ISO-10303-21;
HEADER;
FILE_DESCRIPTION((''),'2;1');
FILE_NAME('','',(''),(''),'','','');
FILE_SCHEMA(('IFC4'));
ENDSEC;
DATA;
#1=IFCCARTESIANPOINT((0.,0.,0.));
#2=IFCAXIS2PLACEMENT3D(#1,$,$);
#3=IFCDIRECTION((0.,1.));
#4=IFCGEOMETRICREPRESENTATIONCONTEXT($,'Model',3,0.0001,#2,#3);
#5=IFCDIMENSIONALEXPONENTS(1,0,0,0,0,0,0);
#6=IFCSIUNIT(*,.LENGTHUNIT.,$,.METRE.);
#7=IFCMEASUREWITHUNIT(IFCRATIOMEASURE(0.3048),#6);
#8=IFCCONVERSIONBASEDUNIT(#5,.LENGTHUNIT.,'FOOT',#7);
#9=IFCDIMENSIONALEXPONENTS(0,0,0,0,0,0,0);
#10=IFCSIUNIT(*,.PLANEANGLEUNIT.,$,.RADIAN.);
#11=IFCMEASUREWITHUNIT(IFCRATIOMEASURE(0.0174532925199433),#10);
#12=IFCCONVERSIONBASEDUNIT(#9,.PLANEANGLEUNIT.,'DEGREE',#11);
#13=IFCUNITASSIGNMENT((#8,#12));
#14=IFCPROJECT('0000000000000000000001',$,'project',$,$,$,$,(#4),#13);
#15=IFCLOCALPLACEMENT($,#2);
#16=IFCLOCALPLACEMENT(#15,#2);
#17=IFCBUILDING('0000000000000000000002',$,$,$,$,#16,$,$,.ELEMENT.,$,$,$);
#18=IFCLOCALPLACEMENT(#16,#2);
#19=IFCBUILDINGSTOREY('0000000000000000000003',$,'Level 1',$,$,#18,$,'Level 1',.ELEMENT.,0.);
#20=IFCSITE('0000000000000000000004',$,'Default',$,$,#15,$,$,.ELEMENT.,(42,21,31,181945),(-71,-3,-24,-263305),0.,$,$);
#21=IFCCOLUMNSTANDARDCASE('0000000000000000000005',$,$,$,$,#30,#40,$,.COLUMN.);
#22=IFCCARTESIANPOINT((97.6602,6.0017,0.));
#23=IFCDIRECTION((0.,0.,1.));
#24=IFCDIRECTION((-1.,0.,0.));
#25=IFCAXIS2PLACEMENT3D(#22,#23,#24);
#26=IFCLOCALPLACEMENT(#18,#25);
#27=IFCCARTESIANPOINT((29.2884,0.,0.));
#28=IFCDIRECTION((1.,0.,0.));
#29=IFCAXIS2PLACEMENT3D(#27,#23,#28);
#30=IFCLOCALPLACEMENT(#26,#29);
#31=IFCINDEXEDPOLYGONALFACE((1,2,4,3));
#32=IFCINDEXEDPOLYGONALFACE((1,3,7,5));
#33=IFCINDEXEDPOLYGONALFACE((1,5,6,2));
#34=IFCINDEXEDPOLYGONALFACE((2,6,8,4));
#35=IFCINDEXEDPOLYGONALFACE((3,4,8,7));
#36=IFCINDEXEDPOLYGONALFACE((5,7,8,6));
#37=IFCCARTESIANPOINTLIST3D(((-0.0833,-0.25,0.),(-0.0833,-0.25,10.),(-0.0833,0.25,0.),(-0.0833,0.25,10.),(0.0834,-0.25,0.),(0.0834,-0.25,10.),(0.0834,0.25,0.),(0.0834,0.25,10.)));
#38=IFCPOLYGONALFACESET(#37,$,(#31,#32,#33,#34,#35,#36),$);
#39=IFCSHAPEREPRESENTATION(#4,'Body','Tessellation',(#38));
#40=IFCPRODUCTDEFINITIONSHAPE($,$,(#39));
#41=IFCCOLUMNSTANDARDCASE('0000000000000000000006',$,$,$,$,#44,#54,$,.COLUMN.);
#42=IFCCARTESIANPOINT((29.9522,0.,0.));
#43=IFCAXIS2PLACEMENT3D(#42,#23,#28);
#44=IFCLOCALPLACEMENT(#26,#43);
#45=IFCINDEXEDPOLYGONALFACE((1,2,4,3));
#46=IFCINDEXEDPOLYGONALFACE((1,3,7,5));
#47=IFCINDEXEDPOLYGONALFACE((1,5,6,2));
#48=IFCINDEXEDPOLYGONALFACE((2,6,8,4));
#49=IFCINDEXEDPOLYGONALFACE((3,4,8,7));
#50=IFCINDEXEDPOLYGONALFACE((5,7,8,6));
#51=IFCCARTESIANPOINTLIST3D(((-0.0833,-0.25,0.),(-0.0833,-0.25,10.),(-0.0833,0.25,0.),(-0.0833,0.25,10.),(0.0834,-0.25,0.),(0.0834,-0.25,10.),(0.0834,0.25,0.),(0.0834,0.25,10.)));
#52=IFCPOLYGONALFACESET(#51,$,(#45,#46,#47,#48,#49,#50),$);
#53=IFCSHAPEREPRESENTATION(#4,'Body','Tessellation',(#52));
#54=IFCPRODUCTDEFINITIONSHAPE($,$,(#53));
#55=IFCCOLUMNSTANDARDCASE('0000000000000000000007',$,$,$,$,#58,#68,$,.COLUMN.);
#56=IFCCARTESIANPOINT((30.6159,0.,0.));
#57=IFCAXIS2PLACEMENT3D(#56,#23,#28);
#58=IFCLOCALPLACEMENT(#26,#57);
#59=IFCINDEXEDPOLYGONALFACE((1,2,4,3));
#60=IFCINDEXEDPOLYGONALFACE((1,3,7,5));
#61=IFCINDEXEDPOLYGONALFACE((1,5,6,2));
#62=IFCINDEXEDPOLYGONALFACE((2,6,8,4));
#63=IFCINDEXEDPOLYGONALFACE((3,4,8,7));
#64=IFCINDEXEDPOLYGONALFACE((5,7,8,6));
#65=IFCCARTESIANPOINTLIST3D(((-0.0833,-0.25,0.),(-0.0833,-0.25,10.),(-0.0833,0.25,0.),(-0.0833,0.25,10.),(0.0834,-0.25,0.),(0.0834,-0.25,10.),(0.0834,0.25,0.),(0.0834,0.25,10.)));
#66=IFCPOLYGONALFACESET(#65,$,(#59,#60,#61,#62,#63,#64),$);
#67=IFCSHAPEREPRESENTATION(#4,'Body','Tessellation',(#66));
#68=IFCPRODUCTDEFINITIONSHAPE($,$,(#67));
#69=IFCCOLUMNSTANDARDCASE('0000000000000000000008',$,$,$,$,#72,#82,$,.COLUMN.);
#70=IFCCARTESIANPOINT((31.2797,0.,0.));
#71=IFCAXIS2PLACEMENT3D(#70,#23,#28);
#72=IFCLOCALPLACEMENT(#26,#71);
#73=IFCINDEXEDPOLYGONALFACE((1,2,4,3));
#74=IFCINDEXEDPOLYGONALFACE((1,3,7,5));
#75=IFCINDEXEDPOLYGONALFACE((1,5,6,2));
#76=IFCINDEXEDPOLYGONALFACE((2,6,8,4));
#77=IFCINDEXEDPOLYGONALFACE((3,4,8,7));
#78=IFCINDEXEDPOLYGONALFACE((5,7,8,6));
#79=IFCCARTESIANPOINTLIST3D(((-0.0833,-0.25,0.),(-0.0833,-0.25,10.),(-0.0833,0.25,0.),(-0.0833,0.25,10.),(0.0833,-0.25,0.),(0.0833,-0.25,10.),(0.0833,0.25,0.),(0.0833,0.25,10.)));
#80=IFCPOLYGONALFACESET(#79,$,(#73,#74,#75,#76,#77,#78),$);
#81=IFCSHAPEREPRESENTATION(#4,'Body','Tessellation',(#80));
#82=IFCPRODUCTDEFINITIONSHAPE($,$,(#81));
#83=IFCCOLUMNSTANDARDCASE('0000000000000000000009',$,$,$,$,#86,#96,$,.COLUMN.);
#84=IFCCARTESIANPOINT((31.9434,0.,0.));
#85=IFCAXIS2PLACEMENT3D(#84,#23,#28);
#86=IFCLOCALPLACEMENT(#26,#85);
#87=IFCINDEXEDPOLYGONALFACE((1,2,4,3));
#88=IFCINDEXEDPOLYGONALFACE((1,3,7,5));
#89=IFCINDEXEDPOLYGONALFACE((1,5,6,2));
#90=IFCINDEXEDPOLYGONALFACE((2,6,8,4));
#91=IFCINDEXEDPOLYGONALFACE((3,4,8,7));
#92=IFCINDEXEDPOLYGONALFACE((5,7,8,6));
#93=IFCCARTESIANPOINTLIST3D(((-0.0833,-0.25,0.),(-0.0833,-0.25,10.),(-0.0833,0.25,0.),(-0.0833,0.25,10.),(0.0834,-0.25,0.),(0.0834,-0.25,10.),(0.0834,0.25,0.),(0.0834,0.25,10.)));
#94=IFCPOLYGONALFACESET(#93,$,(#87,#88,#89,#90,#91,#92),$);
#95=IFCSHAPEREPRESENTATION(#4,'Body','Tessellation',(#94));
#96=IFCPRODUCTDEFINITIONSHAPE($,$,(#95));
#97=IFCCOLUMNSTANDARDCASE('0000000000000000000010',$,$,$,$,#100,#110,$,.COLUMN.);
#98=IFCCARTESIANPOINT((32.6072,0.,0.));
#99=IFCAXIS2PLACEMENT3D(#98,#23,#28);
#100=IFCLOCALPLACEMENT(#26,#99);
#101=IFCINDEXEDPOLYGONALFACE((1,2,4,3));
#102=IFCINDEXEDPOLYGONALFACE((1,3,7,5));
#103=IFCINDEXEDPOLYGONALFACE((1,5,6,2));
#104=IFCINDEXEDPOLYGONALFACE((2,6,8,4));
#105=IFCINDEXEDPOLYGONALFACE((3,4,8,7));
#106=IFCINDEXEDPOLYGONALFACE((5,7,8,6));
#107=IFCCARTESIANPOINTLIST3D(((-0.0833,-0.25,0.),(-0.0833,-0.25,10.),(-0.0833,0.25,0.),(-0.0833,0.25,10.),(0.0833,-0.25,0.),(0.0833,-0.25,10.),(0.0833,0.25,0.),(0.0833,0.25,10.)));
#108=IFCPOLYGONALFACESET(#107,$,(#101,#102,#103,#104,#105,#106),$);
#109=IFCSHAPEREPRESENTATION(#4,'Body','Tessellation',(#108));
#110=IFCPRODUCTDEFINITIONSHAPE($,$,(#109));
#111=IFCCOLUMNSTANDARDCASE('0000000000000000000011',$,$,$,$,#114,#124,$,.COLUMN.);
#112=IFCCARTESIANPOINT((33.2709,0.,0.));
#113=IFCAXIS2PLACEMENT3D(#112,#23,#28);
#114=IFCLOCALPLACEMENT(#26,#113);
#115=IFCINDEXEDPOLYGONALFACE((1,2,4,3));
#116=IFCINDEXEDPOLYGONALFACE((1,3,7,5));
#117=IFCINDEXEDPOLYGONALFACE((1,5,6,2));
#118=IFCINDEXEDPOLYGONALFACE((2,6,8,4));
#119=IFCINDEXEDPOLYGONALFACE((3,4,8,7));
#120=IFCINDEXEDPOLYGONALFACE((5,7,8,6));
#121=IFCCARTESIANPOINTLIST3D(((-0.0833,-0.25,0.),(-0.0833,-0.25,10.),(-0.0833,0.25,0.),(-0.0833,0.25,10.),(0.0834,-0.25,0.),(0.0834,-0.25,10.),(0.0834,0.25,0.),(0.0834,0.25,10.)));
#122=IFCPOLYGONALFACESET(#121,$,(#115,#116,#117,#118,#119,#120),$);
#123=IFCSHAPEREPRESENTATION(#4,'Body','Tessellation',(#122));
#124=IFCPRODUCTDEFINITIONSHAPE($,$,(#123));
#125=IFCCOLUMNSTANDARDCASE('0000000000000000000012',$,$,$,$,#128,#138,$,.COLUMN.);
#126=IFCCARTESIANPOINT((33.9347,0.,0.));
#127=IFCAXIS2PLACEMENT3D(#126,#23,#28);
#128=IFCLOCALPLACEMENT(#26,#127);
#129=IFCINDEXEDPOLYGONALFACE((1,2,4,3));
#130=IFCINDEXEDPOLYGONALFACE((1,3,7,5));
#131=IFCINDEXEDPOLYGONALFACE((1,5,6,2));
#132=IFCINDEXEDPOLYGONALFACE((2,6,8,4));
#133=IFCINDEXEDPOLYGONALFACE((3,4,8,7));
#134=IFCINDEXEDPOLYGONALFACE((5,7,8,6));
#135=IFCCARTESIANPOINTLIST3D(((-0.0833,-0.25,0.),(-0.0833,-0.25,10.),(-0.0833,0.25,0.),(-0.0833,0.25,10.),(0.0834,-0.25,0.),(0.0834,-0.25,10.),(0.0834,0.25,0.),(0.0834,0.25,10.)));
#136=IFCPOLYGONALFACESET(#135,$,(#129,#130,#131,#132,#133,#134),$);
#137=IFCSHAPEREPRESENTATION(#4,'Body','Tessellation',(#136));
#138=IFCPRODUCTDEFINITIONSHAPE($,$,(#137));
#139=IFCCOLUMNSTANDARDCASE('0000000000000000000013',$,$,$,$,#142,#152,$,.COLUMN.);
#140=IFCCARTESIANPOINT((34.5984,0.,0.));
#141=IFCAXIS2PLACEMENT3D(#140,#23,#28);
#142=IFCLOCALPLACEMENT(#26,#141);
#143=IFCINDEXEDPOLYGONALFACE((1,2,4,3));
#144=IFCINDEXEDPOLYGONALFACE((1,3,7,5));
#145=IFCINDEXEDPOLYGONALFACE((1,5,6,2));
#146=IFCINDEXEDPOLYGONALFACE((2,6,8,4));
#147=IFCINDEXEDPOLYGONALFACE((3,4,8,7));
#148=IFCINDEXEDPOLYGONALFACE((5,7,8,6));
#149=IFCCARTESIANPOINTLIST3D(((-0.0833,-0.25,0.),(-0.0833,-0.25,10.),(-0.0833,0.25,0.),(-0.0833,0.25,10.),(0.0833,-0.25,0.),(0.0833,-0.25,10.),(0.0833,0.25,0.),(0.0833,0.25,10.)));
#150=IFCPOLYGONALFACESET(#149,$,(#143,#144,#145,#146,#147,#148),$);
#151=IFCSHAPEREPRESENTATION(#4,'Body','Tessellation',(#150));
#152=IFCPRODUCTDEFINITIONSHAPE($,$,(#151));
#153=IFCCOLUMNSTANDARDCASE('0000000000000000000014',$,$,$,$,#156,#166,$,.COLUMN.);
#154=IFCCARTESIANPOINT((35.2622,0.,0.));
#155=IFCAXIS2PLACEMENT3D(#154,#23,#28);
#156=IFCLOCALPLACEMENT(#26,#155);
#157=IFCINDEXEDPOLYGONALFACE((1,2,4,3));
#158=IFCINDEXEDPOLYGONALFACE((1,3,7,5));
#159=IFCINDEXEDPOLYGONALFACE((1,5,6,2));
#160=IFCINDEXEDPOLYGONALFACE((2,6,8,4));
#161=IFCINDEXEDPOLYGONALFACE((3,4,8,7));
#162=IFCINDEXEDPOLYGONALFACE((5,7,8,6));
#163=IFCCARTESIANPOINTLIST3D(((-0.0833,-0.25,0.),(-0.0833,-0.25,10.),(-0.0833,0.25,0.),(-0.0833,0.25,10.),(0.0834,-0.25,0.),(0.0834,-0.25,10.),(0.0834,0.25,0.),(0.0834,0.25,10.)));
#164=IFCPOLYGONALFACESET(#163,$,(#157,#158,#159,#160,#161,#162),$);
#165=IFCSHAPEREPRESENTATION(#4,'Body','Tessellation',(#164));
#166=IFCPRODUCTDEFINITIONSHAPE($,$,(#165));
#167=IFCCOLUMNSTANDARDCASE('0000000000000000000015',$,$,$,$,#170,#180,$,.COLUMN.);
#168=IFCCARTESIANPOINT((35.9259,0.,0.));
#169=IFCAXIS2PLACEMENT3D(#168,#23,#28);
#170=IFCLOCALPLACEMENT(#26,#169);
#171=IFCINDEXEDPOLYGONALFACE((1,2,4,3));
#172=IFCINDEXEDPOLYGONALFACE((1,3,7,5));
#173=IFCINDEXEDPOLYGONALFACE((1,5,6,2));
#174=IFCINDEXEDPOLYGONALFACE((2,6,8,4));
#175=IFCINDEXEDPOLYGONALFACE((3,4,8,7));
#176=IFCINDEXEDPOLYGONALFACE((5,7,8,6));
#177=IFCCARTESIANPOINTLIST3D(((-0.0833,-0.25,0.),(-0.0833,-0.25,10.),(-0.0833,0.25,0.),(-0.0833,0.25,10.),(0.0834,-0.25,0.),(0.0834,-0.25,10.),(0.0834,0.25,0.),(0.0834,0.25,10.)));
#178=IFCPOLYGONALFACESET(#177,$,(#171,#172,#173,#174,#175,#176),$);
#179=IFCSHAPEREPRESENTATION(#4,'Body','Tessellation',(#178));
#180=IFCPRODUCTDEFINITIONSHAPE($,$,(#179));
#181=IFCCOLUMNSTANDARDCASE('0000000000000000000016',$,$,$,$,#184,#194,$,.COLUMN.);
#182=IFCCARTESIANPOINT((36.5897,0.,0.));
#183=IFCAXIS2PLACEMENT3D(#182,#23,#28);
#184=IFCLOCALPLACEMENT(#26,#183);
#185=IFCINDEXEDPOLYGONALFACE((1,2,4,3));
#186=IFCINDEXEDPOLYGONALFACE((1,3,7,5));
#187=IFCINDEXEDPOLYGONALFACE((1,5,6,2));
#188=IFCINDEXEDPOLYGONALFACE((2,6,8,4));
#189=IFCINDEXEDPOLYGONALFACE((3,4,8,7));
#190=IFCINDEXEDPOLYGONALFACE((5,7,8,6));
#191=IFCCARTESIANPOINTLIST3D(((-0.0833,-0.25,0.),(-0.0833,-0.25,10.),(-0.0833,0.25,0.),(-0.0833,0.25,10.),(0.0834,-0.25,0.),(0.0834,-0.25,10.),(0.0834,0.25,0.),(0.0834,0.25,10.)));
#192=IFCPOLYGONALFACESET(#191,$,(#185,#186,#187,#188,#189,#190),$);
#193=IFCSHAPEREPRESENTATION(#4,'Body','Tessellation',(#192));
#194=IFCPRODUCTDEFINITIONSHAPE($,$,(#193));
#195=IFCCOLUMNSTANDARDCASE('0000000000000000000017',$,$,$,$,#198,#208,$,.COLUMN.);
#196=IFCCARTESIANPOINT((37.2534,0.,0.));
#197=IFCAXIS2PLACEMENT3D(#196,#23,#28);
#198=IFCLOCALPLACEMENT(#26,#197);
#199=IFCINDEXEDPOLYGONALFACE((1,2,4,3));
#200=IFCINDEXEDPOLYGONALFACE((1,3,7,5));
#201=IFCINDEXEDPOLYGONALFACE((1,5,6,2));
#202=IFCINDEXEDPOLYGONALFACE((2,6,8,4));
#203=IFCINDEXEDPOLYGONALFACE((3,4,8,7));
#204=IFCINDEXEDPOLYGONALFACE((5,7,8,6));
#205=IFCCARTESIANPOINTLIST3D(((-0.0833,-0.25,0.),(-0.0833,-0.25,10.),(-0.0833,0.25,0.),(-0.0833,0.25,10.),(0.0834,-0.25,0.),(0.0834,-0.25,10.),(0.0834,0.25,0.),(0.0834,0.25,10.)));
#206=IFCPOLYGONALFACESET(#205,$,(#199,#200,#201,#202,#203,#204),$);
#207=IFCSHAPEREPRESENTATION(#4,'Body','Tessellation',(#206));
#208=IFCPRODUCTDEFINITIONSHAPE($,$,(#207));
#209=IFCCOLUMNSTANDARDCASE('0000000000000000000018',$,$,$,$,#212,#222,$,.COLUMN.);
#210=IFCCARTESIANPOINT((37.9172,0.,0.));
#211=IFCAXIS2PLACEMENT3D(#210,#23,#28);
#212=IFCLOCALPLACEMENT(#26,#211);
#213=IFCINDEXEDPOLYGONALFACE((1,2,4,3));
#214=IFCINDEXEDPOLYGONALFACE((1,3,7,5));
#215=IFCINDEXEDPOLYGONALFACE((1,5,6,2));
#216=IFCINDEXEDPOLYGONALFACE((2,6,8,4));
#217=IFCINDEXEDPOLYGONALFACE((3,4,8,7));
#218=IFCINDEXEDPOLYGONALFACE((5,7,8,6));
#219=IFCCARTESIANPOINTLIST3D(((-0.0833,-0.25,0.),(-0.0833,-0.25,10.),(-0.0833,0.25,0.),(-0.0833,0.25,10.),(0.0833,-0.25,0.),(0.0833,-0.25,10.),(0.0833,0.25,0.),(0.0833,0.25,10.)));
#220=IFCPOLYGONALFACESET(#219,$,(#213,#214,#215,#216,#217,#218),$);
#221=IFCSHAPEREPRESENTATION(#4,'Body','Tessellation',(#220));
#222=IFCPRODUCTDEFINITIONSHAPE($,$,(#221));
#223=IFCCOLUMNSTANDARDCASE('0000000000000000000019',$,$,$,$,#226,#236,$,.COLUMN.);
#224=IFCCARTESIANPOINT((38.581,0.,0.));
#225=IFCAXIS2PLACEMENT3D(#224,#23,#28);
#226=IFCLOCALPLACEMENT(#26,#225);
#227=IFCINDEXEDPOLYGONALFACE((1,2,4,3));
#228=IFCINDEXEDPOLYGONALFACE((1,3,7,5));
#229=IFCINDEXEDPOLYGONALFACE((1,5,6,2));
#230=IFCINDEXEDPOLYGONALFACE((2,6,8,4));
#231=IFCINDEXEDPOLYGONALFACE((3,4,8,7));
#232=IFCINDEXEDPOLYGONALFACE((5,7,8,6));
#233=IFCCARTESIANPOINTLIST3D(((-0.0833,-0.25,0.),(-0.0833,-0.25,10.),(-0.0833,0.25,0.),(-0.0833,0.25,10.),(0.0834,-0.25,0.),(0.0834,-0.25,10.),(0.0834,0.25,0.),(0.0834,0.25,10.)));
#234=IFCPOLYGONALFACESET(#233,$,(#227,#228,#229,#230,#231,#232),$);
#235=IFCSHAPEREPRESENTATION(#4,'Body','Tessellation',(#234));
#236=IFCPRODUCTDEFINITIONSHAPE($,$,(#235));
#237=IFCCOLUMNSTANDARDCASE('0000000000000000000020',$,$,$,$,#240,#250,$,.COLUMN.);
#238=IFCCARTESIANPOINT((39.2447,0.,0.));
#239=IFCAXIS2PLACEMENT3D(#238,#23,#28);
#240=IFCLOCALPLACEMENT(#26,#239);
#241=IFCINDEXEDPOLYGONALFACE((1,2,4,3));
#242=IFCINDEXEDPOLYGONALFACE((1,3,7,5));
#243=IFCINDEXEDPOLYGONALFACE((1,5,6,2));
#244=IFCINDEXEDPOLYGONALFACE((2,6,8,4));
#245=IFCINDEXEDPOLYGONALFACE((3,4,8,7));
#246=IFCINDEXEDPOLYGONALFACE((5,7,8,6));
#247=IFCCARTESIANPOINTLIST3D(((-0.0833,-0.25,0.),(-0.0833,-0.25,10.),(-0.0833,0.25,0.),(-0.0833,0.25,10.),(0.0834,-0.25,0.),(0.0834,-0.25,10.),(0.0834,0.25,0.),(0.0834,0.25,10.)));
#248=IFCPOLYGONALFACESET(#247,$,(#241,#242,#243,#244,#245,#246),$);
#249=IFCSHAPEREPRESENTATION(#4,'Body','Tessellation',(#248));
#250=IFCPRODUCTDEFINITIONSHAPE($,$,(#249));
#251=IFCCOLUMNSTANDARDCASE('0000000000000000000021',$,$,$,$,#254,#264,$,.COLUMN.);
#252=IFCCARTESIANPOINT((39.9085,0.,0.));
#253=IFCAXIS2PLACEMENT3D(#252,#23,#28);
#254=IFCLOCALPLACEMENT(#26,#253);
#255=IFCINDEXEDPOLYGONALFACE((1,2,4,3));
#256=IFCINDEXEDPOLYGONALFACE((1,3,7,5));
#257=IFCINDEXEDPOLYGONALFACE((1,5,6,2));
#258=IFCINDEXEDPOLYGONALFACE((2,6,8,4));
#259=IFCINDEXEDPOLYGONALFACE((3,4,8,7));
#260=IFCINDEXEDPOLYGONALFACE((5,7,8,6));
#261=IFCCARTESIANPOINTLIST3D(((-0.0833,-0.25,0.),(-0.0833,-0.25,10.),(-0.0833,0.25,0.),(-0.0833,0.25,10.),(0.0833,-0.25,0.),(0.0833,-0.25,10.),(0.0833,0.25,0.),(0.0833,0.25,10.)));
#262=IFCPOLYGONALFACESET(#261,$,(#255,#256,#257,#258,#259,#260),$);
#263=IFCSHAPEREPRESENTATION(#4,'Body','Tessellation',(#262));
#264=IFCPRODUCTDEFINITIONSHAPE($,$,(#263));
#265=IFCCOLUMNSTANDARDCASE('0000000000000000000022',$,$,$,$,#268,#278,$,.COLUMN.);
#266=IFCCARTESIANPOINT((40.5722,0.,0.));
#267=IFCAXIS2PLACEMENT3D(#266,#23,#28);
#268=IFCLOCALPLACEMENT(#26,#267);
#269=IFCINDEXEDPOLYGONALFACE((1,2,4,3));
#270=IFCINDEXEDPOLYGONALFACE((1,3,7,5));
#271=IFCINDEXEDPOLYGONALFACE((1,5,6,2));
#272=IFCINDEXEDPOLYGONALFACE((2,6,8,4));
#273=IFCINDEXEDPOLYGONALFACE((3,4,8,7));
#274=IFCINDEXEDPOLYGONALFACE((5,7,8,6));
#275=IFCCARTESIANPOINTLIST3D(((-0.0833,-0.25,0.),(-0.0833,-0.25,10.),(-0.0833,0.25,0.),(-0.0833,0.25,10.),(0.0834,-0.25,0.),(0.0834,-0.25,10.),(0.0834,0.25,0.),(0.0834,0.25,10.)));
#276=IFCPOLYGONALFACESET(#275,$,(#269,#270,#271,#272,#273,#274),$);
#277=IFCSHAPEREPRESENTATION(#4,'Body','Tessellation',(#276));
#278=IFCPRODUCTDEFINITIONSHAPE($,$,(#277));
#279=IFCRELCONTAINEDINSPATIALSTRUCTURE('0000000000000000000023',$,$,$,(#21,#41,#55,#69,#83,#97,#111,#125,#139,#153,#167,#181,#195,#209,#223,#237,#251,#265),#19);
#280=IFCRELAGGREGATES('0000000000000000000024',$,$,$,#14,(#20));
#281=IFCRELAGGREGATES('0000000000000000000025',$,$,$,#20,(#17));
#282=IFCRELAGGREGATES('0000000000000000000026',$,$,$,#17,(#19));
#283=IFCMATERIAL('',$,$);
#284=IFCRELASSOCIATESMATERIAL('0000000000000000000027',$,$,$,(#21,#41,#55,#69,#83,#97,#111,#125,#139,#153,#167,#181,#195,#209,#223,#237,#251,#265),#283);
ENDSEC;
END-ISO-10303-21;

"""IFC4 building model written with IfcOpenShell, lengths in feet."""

from ifc_helpers import new_model, entity, si_unit, converted_unit, direction, frame, origin, place, context, project, spatial, rectangle, extrude, material, element, save


model = new_model("IFC4")

# Units and contexts
model_context = context("Model", 3, precision=0.0001, world=origin(), true_north=direction((0.0, 1.0)))
ifc_project = project(units=[converted_unit("LENGTHUNIT", "FOOT", entity("IfcRatioMeasure", 0.3048), si_unit("LENGTHUNIT", "METRE"), dimensions=[1, 0, 0, 0, 0, 0, 0]), converted_unit("PLANEANGLEUNIT", "DEGREE", entity("IfcRatioMeasure", 0.0174532925199433), si_unit("PLANEANGLEUNIT", "RADIAN"), dimensions=[0, 0, 0, 0, 0, 0, 0])], contexts=[model_context])

# Site, building, storey
site_placement = place(None, origin())
site = spatial("IfcSite", under=ifc_project, at=site_placement, Name="Default", CompositionType="ELEMENT", RefLatitude=(42, 21, 31, 181945), RefLongitude=(-71, -3, -24, -263305), RefElevation=0.0)
building_placement = place(site_placement, origin())
building = spatial("IfcBuilding", under=site, at=building_placement, CompositionType="ELEMENT")
storey_placement = place(building_placement, origin())
storey = spatial("IfcBuildingStorey", under=building, at=storey_placement, Name="Level 1", LongName="Level 1", CompositionType="ELEMENT", Elevation=0.0)

# Columns
ifc_material_1 = material(Name="")
placement = place(storey_placement, frame((97.6602, 6.0017, 0.0), z_axis=(0.0, 0.0, 1.0), x_axis=(-1.0, 0.0, 0.0)))
for number, where, z_axis, x_axis in (
    (1, (29.2884, 0.0, 0.0), (0.0, 0.0, 1.0), (1.0, 0.0, 0.0)),
    (2, (29.9522, 0.0, 0.0), (0.0, 0.0, 1.0), (1.0, 0.0, 0.0)),
    (3, (30.6159, 0.0, 0.0), (0.0, 0.0, 1.0), (1.0, 0.0, 0.0)),
    (4, (31.2797, 0.0, 0.0), (0.0, 0.0, 1.0), (1.0, 0.0, 0.0)),
    (5, (31.9434, 0.0, 0.0), (0.0, 0.0, 1.0), (1.0, 0.0, 0.0)),
    (6, (32.6072, 0.0, 0.0), (0.0, 0.0, 1.0), (1.0, 0.0, 0.0)),
    (7, (33.2709, 0.0, 0.0), (0.0, 0.0, 1.0), (1.0, 0.0, 0.0)),
    (8, (33.9347, 0.0, 0.0), (0.0, 0.0, 1.0), (1.0, 0.0, 0.0)),
    (9, (34.5984, 0.0, 0.0), (0.0, 0.0, 1.0), (1.0, 0.0, 0.0)),
    (10, (35.2622, 0.0, 0.0), (0.0, 0.0, 1.0), (1.0, 0.0, 0.0)),
    (11, (35.9259, 0.0, 0.0), (0.0, 0.0, 1.0), (1.0, 0.0, 0.0)),
    (12, (36.5897, 0.0, 0.0), (0.0, 0.0, 1.0), (1.0, 0.0, 0.0)),
    (13, (37.2534, 0.0, 0.0), (0.0, 0.0, 1.0), (1.0, 0.0, 0.0)),
    (14, (37.9172, 0.0, 0.0), (0.0, 0.0, 1.0), (1.0, 0.0, 0.0)),
    (15, (38.581, 0.0, 0.0), (0.0, 0.0, 1.0), (1.0, 0.0, 0.0)),
    (16, (39.2447, 0.0, 0.0), (0.0, 0.0, 1.0), (1.0, 0.0, 0.0)),
    (17, (39.9085, 0.0, 0.0), (0.0, 0.0, 1.0), (1.0, 0.0, 0.0)),
    (18, (40.5722, 0.0, 0.0), (0.0, 0.0, 1.0), (1.0, 0.0, 0.0)),
):
    element("IfcColumnStandardCase", number, at=place(placement, frame(where, z_axis=z_axis, x_axis=x_axis)), inside=storey, material=ifc_material_1, PredefinedType="COLUMN", context=model_context, shape_type="SweptSolid", body=[
        extrude(rectangle(XDim=0.1667, YDim=0.5), origin(), (0.0, 0.0, 1.0), 10.0),
    ])

save(model, "model.ifc")
